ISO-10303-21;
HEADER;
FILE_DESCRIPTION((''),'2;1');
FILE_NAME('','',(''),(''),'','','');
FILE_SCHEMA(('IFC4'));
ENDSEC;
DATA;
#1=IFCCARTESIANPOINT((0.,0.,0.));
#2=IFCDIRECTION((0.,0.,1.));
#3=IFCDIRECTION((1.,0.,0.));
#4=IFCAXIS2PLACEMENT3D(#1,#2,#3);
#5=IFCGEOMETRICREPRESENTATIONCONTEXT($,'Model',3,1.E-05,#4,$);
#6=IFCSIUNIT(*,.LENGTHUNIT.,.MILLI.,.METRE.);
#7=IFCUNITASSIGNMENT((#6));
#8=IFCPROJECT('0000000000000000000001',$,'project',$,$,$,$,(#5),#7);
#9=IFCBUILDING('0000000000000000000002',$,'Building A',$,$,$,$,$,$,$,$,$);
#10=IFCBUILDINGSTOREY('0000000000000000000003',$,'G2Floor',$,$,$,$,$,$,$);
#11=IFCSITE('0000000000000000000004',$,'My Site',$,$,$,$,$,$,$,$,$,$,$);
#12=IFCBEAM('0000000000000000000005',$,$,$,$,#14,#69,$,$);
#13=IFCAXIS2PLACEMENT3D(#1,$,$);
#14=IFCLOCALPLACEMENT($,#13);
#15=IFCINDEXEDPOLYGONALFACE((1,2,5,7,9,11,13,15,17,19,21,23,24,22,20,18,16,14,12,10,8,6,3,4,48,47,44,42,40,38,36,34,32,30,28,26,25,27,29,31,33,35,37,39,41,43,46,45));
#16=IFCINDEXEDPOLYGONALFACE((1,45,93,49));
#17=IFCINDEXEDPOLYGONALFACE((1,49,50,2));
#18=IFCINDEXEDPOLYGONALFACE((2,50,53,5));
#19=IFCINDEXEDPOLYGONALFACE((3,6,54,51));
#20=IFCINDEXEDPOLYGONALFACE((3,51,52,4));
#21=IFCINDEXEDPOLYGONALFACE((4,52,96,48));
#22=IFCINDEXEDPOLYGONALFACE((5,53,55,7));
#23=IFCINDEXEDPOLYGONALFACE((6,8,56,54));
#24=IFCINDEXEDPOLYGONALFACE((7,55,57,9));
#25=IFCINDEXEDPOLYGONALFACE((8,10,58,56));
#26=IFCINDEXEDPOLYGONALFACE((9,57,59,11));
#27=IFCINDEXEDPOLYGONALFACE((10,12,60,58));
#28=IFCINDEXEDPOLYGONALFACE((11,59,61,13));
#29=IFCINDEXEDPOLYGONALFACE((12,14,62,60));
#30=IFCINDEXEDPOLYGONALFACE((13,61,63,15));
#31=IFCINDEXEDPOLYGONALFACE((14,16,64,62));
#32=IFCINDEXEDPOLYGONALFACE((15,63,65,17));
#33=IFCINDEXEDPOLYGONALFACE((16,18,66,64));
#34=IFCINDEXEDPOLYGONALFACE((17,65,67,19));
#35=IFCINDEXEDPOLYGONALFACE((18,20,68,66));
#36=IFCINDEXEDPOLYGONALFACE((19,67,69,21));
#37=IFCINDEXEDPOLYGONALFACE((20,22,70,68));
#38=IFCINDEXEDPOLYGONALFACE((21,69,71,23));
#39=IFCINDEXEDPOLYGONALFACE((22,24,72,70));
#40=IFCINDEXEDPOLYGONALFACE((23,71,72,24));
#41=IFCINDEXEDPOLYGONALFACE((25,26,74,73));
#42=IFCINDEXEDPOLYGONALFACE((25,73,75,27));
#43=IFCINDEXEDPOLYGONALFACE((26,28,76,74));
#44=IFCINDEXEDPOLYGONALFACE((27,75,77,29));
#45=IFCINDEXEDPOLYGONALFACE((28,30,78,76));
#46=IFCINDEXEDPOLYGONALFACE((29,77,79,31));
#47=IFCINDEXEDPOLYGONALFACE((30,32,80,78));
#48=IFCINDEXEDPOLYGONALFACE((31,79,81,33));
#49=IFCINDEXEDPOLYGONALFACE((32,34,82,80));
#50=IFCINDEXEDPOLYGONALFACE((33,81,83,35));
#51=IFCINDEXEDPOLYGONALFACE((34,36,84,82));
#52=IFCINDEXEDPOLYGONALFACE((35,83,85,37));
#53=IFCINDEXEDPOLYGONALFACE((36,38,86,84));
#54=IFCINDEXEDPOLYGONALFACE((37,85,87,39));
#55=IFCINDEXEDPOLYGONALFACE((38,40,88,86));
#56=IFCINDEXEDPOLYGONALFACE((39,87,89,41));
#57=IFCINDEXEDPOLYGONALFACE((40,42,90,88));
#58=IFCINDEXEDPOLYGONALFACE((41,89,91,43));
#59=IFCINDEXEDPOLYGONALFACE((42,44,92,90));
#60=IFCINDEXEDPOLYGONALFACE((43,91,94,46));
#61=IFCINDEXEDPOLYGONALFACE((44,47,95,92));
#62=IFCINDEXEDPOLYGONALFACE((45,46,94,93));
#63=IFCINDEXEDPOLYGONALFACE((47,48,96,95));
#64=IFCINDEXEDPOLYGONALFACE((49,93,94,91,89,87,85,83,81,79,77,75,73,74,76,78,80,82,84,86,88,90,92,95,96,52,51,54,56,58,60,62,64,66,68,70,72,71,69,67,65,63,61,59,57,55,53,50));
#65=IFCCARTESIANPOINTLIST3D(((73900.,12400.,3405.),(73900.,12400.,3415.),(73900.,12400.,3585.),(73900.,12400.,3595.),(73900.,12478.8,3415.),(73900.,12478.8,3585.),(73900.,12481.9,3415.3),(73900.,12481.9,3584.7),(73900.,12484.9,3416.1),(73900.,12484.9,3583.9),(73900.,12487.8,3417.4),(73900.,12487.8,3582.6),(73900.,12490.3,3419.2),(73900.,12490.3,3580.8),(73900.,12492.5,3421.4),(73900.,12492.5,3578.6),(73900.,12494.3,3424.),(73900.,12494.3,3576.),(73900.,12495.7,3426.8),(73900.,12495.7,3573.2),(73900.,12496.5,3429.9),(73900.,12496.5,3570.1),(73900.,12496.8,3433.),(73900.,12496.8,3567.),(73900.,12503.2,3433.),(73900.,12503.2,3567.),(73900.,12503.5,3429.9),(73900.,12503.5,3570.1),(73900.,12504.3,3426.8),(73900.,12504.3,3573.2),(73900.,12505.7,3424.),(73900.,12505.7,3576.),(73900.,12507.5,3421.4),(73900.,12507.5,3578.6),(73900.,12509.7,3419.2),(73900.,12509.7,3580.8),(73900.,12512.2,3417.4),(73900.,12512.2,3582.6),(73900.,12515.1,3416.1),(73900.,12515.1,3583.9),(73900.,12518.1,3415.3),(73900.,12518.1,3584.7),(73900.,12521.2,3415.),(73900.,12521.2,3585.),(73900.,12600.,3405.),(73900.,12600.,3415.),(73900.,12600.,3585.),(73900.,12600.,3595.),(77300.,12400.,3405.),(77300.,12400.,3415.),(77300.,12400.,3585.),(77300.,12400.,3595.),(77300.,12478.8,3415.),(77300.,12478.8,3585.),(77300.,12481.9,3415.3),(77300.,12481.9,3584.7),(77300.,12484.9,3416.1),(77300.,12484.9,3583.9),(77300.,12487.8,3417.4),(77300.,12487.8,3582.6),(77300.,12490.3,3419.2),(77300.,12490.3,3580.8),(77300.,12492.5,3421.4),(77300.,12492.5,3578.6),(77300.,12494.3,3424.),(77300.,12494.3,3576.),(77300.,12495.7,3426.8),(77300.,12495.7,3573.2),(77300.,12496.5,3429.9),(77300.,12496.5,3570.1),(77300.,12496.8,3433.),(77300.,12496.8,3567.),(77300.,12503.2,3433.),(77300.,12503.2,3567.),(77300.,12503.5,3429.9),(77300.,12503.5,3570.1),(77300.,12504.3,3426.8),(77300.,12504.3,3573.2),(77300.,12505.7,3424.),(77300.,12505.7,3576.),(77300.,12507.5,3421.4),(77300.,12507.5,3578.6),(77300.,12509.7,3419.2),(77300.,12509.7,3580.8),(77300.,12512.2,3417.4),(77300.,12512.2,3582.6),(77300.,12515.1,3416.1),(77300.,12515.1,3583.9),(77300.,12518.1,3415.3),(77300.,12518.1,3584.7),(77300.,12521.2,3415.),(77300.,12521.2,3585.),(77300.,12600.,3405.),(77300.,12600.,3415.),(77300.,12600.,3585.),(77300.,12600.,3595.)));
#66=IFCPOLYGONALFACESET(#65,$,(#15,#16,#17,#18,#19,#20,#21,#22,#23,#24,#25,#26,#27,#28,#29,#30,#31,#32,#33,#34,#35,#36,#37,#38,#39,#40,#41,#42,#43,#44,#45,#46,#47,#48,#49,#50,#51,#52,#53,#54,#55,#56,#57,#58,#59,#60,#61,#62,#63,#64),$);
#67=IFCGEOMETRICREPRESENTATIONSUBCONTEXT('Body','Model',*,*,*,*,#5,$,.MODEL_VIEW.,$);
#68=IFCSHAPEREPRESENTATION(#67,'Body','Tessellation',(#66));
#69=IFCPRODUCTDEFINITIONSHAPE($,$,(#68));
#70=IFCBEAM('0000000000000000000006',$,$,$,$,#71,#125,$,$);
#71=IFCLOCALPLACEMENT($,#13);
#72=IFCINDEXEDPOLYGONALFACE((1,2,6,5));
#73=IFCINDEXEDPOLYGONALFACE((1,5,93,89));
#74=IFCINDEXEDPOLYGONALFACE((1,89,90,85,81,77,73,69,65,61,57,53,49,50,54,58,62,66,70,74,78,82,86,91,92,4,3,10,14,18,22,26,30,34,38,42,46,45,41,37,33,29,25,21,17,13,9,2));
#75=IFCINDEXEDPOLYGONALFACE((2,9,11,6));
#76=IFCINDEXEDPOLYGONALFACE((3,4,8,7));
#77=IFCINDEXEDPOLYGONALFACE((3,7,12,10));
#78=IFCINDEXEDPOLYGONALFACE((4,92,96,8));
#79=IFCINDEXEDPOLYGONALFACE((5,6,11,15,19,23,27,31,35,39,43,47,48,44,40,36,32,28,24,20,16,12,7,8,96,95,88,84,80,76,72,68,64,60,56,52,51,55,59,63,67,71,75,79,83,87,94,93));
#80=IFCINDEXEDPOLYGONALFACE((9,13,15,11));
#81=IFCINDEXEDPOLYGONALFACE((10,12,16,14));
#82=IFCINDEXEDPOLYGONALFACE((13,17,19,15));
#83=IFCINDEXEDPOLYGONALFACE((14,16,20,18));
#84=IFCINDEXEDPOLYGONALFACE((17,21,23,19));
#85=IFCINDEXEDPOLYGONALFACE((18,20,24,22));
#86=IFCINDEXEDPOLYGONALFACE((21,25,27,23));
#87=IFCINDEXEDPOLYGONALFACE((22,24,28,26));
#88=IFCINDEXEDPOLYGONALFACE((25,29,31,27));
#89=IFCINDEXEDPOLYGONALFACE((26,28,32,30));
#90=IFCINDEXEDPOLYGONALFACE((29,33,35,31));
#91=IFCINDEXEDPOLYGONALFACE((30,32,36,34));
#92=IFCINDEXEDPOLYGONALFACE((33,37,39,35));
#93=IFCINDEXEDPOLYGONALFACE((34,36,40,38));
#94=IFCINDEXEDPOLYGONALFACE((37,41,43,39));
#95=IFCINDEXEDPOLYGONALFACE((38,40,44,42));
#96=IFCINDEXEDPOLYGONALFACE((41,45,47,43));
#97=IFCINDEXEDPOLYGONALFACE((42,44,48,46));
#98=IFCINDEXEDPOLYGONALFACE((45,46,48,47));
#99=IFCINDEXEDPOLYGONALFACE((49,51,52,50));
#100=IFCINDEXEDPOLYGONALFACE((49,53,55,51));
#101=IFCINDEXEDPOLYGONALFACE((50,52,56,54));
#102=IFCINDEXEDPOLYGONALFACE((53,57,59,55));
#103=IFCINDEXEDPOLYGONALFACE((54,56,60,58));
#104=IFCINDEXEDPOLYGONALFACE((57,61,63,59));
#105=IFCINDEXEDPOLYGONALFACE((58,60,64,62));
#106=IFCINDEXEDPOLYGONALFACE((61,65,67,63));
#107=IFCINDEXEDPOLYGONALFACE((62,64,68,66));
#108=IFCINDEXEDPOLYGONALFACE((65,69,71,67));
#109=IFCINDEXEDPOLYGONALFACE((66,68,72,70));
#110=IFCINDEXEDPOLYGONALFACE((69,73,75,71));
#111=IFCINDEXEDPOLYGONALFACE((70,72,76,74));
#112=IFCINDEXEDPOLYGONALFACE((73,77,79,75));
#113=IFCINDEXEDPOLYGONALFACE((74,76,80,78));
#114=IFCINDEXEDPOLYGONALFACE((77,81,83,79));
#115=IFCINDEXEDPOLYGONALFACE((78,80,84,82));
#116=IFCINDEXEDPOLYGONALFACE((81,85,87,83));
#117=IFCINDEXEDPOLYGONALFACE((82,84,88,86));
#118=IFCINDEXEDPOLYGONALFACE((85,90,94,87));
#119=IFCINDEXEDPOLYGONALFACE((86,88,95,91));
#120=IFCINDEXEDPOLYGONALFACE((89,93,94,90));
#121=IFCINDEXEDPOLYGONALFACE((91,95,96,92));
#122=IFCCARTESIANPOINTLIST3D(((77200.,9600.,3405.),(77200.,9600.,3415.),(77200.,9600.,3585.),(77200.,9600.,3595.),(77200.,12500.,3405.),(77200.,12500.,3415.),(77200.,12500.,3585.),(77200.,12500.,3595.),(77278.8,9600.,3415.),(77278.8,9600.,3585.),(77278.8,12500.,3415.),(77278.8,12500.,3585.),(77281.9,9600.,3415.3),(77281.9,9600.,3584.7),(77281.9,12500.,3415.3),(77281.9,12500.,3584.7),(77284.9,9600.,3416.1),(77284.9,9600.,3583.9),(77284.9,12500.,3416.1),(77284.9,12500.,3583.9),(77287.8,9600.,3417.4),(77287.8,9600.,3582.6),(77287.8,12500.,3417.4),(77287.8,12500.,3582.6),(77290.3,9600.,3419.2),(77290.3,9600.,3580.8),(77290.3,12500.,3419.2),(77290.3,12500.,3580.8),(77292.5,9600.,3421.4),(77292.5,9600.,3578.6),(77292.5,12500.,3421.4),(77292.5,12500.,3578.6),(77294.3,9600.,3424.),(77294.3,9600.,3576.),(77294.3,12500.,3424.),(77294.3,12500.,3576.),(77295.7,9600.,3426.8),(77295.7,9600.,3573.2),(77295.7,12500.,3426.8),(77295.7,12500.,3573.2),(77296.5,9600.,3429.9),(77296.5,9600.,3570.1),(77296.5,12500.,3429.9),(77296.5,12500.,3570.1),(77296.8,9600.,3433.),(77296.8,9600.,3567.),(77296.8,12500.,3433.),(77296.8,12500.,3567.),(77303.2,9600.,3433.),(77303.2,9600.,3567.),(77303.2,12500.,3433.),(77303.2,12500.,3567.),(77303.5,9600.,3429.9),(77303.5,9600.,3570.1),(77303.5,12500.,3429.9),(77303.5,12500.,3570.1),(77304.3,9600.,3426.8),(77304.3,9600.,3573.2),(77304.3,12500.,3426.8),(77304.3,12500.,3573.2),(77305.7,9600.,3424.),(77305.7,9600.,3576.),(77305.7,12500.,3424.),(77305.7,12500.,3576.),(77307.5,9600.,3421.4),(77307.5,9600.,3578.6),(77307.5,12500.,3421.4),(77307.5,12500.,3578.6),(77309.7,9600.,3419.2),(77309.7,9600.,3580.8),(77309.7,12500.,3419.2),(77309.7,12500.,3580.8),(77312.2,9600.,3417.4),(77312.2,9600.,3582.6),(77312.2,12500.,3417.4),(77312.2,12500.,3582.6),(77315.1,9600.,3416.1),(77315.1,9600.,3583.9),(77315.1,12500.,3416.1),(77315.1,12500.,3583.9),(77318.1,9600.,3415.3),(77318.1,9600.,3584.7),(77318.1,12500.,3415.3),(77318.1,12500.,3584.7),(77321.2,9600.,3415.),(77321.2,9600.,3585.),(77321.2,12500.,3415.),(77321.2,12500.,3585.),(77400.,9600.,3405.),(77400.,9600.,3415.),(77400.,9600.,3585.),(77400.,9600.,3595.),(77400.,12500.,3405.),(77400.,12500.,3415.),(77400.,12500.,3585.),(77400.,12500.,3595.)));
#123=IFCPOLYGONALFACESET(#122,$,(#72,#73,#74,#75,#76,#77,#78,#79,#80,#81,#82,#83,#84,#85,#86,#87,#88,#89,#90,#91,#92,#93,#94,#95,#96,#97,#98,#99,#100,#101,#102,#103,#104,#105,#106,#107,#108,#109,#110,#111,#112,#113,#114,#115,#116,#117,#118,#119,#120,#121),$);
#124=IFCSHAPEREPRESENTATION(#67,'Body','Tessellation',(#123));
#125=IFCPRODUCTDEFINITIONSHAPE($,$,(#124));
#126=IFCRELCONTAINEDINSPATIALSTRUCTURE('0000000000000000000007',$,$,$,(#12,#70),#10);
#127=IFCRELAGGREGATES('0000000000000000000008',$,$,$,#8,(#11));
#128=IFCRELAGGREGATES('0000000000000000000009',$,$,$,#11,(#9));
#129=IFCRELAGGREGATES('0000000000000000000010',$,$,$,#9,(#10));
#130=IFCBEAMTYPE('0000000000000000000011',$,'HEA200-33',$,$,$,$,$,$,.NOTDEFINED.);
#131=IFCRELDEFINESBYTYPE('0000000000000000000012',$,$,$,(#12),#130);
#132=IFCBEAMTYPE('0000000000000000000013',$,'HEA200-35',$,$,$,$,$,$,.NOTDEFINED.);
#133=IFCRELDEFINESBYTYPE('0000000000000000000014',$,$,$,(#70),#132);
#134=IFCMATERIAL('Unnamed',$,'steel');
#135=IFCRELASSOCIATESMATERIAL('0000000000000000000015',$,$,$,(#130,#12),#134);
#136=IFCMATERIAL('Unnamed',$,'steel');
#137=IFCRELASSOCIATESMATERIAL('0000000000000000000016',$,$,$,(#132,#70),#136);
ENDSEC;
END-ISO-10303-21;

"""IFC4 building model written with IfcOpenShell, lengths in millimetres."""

from ifc_helpers import new_model, si_unit, frame, origin_with_axes, place, context, subcontext, project, spatial, polyline, outline, extrude, material, material_profile, profile_set, profile_usage, type_object, element, save


model = new_model("IFC4")

# Units and contexts
model_context = context("Model", 3, precision=1e-05, world=origin_with_axes())
body_context = subcontext(model_context, "Body", "Model", "MODEL_VIEW")
ifc_project = project(units=[si_unit("LENGTHUNIT", "METRE", prefix="MILLI")], contexts=[model_context])

# Site, building, storey
site = spatial("IfcSite", under=ifc_project, Name="My Site")
building = spatial("IfcBuilding", under=site, Name="Building A")
storey = spatial("IfcBuildingStorey", under=building, Name="G2Floor")

# Beams
ifc_material_1 = material(Name="Unnamed", Category="steel")
ifc_material_profile_1 = material_profile(ifc_material_1, outline(polyline([(100.0, -95.0), (100.0, -85.0), (100.0, -85.0), (21.2, -85.0), (21.2, -85.0), (18.1, -84.7), (18.1, -84.7), (15.1, -83.9), (15.1, -83.9), (12.2, -82.6), (12.2, -82.6), (9.7, -80.8), (9.7, -80.8), (7.5, -78.6), (7.5, -78.6), (5.7, -76.0), (5.7, -76.0), (4.3, -73.2), (4.3, -73.2), (3.5, -70.1), (3.5, -70.1), (3.2, -67.0), (3.2, -67.0), (3.2, 67.0), (3.2, 67.0), (3.5, 70.1), (3.5, 70.1), (4.3, 73.2), (4.3, 73.2), (5.7, 76.0), (5.7, 76.0), (7.5, 78.6), (7.5, 78.6), (9.7, 80.8), (9.7, 80.8), (12.2, 82.6), (12.2, 82.6), (15.1, 83.9), (15.1, 83.9), (18.1, 84.7), (18.1, 84.7), (21.2, 85.0), (21.2, 85.0), (100.0, 85.0), (100.0, 85.0), (100.0, 95.0), (100.0, 95.0), (-100.0, 95.0), (-100.0, 95.0), (-100.0, 85.0), (-100.0, 85.0), (-21.2, 85.0), (-21.2, 85.0), (-18.1, 84.7), (-18.1, 84.7), (-15.1, 83.9), (-15.1, 83.9), (-12.2, 82.6), (-12.2, 82.6), (-9.7, 80.8), (-9.7, 80.8), (-7.5, 78.6), (-7.5, 78.6), (-5.7, 76.0), (-5.7, 76.0), (-4.3, 73.2), (-4.3, 73.2), (-3.5, 70.1), (-3.5, 70.1), (-3.2, 67.0), (-3.2, 67.0), (-3.2, -67.0), (-3.2, -67.0), (-3.5, -70.1), (-3.5, -70.1), (-4.3, -73.2), (-4.3, -73.2), (-5.7, -76.0), (-5.7, -76.0), (-7.5, -78.6), (-7.5, -78.6), (-9.7, -80.8), (-9.7, -80.8), (-12.2, -82.6), (-12.2, -82.6), (-15.1, -83.9), (-15.1, -83.9), (-18.1, -84.7), (-18.1, -84.7), (-21.2, -85.0), (-21.2, -85.0), (-100.0, -85.0), (-100.0, -85.0), (-100.0, -95.0), (-100.0, -95.0), (100.0, -95.0)])))
ifc_profile_set_1 = profile_set([ifc_material_profile_1], Name="HEA200-33")
ifc_profile_usage_1 = profile_usage(ifc_profile_set_1)
beam_type_1 = type_object("IfcBeamType", Name="HEA200-33", PredefinedType="NOTDEFINED", material=ifc_profile_set_1)
beam_1_placement = place(None, frame((73900.0, 12500.0, 3500.0), z_axis=(1.0, 0.0, 0.0), x_axis=(0.0, -1.0, 0.0)))
element("IfcBeam", 1, at=beam_1_placement, inside=storey, type_object=beam_type_1, material=ifc_profile_usage_1, context=body_context, shape_type="SweptSolid", body=[
    extrude(outline(polyline([(100.0, -95.0), (100.0, -85.0), (100.0, -85.0), (21.2, -85.0), (21.2, -85.0), (18.1, -84.7), (18.1, -84.7), (15.1, -83.9), (15.1, -83.9), (12.2, -82.6), (12.2, -82.6), (9.7, -80.8), (9.7, -80.8), (7.5, -78.6), (7.5, -78.6), (5.7, -76.0), (5.7, -76.0), (4.3, -73.2), (4.3, -73.2), (3.5, -70.1), (3.5, -70.1), (3.2, -67.0), (3.2, -67.0), (3.2, 67.0), (3.2, 67.0), (3.5, 70.1), (3.5, 70.1), (4.3, 73.2), (4.3, 73.2), (5.7, 76.0), (5.7, 76.0), (7.5, 78.6), (7.5, 78.6), (9.7, 80.8), (9.7, 80.8), (12.2, 82.6), (12.2, 82.6), (15.1, 83.9), (15.1, 83.9), (18.1, 84.7), (18.1, 84.7), (21.2, 85.0), (21.2, 85.0), (100.0, 85.0), (100.0, 85.0), (100.0, 95.0), (100.0, 95.0), (-100.0, 95.0), (-100.0, 95.0), (-100.0, 85.0), (-100.0, 85.0), (-21.2, 85.0), (-21.2, 85.0), (-18.1, 84.7), (-18.1, 84.7), (-15.1, 83.9), (-15.1, 83.9), (-12.2, 82.6), (-12.2, 82.6), (-9.7, 80.8), (-9.7, 80.8), (-7.5, 78.6), (-7.5, 78.6), (-5.7, 76.0), (-5.7, 76.0), (-4.3, 73.2), (-4.3, 73.2), (-3.5, 70.1), (-3.5, 70.1), (-3.2, 67.0), (-3.2, 67.0), (-3.2, -67.0), (-3.2, -67.0), (-3.5, -70.1), (-3.5, -70.1), (-4.3, -73.2), (-4.3, -73.2), (-5.7, -76.0), (-5.7, -76.0), (-7.5, -78.6), (-7.5, -78.6), (-9.7, -80.8), (-9.7, -80.8), (-12.2, -82.6), (-12.2, -82.6), (-15.1, -83.9), (-15.1, -83.9), (-18.1, -84.7), (-18.1, -84.7), (-21.2, -85.0), (-21.2, -85.0), (-100.0, -85.0), (-100.0, -85.0), (-100.0, -95.0), (-100.0, -95.0), (100.0, -95.0)])), origin_with_axes(), (0.0, 0.0, 1.0), 3400.0),
])
ifc_material_2 = material(Name="Unnamed", Category="steel")
ifc_material_profile_2 = material_profile(ifc_material_2, outline(polyline([(100.0, -95.0), (100.0, -85.0), (100.0, -85.0), (21.2, -85.0), (21.2, -85.0), (18.1, -84.7), (18.1, -84.7), (15.1, -83.9), (15.1, -83.9), (12.2, -82.6), (12.2, -82.6), (9.7, -80.8), (9.7, -80.8), (7.5, -78.6), (7.5, -78.6), (5.7, -76.0), (5.7, -76.0), (4.3, -73.2), (4.3, -73.2), (3.5, -70.1), (3.5, -70.1), (3.2, -67.0), (3.2, -67.0), (3.2, 67.0), (3.2, 67.0), (3.5, 70.1), (3.5, 70.1), (4.3, 73.2), (4.3, 73.2), (5.7, 76.0), (5.7, 76.0), (7.5, 78.6), (7.5, 78.6), (9.7, 80.8), (9.7, 80.8), (12.2, 82.6), (12.2, 82.6), (15.1, 83.9), (15.1, 83.9), (18.1, 84.7), (18.1, 84.7), (21.2, 85.0), (21.2, 85.0), (100.0, 85.0), (100.0, 85.0), (100.0, 95.0), (100.0, 95.0), (-100.0, 95.0), (-100.0, 95.0), (-100.0, 85.0), (-100.0, 85.0), (-21.2, 85.0), (-21.2, 85.0), (-18.1, 84.7), (-18.1, 84.7), (-15.1, 83.9), (-15.1, 83.9), (-12.2, 82.6), (-12.2, 82.6), (-9.7, 80.8), (-9.7, 80.8), (-7.5, 78.6), (-7.5, 78.6), (-5.7, 76.0), (-5.7, 76.0), (-4.3, 73.2), (-4.3, 73.2), (-3.5, 70.1), (-3.5, 70.1), (-3.2, 67.0), (-3.2, 67.0), (-3.2, -67.0), (-3.2, -67.0), (-3.5, -70.1), (-3.5, -70.1), (-4.3, -73.2), (-4.3, -73.2), (-5.7, -76.0), (-5.7, -76.0), (-7.5, -78.6), (-7.5, -78.6), (-9.7, -80.8), (-9.7, -80.8), (-12.2, -82.6), (-12.2, -82.6), (-15.1, -83.9), (-15.1, -83.9), (-18.1, -84.7), (-18.1, -84.7), (-21.2, -85.0), (-21.2, -85.0), (-100.0, -85.0), (-100.0, -85.0), (-100.0, -95.0), (-100.0, -95.0), (100.0, -95.0)])))
ifc_profile_set_2 = profile_set([ifc_material_profile_2], Name="HEA200-35")
ifc_profile_usage_2 = profile_usage(ifc_profile_set_2)
beam_type_2 = type_object("IfcBeamType", Name="HEA200-35", PredefinedType="NOTDEFINED", material=ifc_profile_set_2)
beam_2_placement = place(None, frame((77300.0, 9600.0, 3500.0), z_axis=(0.0, 1.0, 0.0), x_axis=(1.0, 0.0, 0.0)))
element("IfcBeam", 2, at=beam_2_placement, inside=storey, type_object=beam_type_2, material=ifc_profile_usage_2, context=body_context, shape_type="SweptSolid", body=[
    extrude(outline(polyline([(100.0, -95.0), (100.0, -85.0), (100.0, -85.0), (21.2, -85.0), (21.2, -85.0), (18.1, -84.7), (18.1, -84.7), (15.1, -83.9), (15.1, -83.9), (12.2, -82.6), (12.2, -82.6), (9.7, -80.8), (9.7, -80.8), (7.5, -78.6), (7.5, -78.6), (5.7, -76.0), (5.7, -76.0), (4.3, -73.2), (4.3, -73.2), (3.5, -70.1), (3.5, -70.1), (3.2, -67.0), (3.2, -67.0), (3.2, 67.0), (3.2, 67.0), (3.5, 70.1), (3.5, 70.1), (4.3, 73.2), (4.3, 73.2), (5.7, 76.0), (5.7, 76.0), (7.5, 78.6), (7.5, 78.6), (9.7, 80.8), (9.7, 80.8), (12.2, 82.6), (12.2, 82.6), (15.1, 83.9), (15.1, 83.9), (18.1, 84.7), (18.1, 84.7), (21.2, 85.0), (21.2, 85.0), (100.0, 85.0), (100.0, 85.0), (100.0, 95.0), (100.0, 95.0), (-100.0, 95.0), (-100.0, 95.0), (-100.0, 85.0), (-100.0, 85.0), (-21.2, 85.0), (-21.2, 85.0), (-18.1, 84.7), (-18.1, 84.7), (-15.1, 83.9), (-15.1, 83.9), (-12.2, 82.6), (-12.2, 82.6), (-9.7, 80.8), (-9.7, 80.8), (-7.5, 78.6), (-7.5, 78.6), (-5.7, 76.0), (-5.7, 76.0), (-4.3, 73.2), (-4.3, 73.2), (-3.5, 70.1), (-3.5, 70.1), (-3.2, 67.0), (-3.2, 67.0), (-3.2, -67.0), (-3.2, -67.0), (-3.5, -70.1), (-3.5, -70.1), (-4.3, -73.2), (-4.3, -73.2), (-5.7, -76.0), (-5.7, -76.0), (-7.5, -78.6), (-7.5, -78.6), (-9.7, -80.8), (-9.7, -80.8), (-12.2, -82.6), (-12.2, -82.6), (-15.1, -83.9), (-15.1, -83.9), (-18.1, -84.7), (-18.1, -84.7), (-21.2, -85.0), (-21.2, -85.0), (-100.0, -85.0), (-100.0, -85.0), (-100.0, -95.0), (-100.0, -95.0), (100.0, -95.0)])), origin_with_axes(), (0.0, 0.0, 1.0), 2900.0),
])

save(model, "model.ifc")
